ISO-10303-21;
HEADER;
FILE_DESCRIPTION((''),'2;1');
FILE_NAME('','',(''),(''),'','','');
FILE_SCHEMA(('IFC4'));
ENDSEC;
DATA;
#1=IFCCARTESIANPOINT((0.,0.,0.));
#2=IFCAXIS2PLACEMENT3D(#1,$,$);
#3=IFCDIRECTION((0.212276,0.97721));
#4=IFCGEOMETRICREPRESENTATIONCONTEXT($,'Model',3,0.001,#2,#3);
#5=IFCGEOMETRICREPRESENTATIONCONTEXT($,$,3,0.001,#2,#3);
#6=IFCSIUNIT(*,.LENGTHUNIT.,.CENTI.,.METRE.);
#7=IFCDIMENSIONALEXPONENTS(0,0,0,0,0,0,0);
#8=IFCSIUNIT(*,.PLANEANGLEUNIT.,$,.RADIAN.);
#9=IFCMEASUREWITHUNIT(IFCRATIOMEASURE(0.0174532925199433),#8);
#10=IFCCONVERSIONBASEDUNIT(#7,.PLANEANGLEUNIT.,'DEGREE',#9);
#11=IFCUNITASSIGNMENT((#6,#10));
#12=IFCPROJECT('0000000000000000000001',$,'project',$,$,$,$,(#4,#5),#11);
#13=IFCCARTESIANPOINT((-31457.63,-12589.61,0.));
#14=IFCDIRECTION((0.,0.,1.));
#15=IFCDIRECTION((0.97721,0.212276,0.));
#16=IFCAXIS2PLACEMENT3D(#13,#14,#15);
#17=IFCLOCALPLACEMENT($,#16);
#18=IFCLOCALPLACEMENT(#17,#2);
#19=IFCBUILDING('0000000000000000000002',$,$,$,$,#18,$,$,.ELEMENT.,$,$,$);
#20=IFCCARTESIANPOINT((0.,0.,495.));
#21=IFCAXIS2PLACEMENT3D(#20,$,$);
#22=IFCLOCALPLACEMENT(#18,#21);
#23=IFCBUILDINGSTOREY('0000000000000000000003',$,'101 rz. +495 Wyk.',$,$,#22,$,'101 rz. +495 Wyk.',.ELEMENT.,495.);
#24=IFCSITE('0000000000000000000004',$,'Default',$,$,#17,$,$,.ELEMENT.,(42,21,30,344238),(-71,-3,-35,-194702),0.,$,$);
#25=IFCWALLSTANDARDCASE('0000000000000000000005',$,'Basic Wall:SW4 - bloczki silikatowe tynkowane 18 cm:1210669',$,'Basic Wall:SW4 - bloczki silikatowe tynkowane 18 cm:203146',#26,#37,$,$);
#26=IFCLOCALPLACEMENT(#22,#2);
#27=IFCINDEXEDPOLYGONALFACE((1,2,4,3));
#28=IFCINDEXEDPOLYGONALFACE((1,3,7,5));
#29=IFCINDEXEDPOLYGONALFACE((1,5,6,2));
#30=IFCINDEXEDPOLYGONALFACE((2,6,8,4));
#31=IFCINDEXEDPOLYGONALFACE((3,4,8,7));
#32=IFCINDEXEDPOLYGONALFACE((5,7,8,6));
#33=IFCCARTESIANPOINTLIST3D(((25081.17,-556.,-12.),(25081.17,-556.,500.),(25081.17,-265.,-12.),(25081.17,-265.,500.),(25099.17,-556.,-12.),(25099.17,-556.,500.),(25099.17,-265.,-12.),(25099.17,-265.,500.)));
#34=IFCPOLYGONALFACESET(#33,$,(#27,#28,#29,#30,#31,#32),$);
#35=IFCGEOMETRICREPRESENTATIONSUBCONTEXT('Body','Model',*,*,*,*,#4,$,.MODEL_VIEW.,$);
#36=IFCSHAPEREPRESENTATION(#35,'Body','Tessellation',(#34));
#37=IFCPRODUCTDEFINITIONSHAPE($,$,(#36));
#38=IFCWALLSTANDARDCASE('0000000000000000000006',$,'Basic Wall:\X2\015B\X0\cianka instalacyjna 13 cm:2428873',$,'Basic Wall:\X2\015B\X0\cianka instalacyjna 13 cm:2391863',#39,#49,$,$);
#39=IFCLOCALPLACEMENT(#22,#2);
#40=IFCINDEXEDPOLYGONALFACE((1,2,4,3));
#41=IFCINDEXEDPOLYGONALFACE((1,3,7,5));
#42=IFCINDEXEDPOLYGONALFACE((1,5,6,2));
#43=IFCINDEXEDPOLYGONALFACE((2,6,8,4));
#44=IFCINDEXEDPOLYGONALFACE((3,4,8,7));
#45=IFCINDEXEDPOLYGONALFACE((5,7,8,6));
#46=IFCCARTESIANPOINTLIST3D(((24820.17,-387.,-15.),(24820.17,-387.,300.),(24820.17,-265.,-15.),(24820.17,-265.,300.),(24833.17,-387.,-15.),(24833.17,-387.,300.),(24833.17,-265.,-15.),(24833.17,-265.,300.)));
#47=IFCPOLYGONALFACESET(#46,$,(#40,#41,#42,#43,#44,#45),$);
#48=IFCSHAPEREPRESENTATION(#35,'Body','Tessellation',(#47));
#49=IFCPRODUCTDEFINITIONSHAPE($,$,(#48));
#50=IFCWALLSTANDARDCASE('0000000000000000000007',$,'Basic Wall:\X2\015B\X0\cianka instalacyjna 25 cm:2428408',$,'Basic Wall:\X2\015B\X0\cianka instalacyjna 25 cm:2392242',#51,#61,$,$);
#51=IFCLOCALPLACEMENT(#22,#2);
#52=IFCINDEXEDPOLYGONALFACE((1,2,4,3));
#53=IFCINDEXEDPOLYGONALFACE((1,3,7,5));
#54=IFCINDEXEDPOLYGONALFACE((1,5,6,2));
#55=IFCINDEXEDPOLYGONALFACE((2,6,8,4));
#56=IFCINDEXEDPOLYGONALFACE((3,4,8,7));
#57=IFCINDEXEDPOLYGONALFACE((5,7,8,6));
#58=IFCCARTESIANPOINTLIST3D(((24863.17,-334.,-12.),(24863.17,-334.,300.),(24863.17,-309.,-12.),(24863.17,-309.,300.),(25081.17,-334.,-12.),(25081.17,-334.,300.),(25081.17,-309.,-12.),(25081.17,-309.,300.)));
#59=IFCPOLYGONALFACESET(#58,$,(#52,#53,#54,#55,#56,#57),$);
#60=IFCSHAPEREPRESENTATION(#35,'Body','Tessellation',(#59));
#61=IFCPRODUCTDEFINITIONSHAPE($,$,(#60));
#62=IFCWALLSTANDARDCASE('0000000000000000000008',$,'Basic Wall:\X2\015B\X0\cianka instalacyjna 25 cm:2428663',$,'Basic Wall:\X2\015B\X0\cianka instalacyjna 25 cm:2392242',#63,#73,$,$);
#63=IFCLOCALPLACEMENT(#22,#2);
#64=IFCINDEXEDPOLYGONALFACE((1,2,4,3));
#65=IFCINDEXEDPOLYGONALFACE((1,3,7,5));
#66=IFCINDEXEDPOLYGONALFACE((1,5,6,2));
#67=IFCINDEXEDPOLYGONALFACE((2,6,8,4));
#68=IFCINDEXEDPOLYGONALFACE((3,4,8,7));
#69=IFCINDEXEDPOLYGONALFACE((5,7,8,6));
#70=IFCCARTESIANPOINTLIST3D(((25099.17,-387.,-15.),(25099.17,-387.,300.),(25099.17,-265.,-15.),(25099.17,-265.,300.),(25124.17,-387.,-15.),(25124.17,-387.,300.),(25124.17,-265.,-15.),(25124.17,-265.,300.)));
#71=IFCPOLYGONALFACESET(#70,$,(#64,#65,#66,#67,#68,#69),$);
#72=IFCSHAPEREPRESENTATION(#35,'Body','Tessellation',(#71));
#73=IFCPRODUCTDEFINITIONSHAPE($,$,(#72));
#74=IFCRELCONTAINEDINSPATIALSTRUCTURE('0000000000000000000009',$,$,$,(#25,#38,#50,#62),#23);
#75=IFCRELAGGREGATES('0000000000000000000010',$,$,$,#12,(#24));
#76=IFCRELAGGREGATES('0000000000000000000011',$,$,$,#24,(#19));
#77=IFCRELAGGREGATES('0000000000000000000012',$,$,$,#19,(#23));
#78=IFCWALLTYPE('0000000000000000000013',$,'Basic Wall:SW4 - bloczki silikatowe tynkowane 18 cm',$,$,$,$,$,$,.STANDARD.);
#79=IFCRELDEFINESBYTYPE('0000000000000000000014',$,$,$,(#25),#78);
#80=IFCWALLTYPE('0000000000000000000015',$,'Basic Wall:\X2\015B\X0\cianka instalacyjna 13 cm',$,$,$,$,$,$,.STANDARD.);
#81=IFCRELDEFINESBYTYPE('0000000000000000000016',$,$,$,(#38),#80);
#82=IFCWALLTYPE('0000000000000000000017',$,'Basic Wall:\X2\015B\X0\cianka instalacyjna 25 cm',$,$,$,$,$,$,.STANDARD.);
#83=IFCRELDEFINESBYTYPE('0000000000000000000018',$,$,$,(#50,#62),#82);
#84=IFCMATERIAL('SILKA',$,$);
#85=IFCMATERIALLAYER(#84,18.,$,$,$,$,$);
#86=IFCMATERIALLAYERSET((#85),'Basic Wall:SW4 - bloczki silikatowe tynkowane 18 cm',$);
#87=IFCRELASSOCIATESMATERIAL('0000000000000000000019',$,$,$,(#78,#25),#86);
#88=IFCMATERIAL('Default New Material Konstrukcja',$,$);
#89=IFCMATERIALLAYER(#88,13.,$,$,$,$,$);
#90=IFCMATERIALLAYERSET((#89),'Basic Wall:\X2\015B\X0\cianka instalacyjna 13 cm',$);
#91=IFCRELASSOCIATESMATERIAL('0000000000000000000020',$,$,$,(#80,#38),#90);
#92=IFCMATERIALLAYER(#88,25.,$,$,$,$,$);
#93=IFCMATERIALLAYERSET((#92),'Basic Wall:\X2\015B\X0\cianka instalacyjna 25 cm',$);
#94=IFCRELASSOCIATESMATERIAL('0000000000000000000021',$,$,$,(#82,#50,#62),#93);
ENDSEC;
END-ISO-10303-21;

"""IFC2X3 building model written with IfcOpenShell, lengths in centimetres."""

from ifc_helpers import new_model, entity, si_unit, converted_unit, direction, frame, frame_2d, origin, place, context, subcontext, project, spatial, polyline, rectangle, extrude, clip, bounded_halfspace, material, layer, layer_set, layer_usage, type_object, element, save


model = new_model("IFC2X3")

# Units and contexts
model_context = context("Model", 3, precision=0.001, world=origin(), true_north=direction((0.212276, 0.97721)))
context_of_model = context(None, 3, precision=0.001, world=origin(), true_north=direction((0.212276, 0.97721)))
body_context = subcontext(model_context, "Body", "Model", "MODEL_VIEW")
ifc_project = project(units=[si_unit("LENGTHUNIT", "METRE", prefix="CENTI"), converted_unit("PLANEANGLEUNIT", "DEGREE", entity("IfcRatioMeasure", 0.0174532925199433), si_unit("PLANEANGLEUNIT", "RADIAN"), dimensions=[0, 0, 0, 0, 0, 0, 0])], contexts=[model_context, context_of_model])

# Site, building, storey
site_placement = place(None, frame((-31457.63, -12589.61, 0.0), z_axis=(0.0, 0.0, 1.0), x_axis=(0.97721, 0.212276, 0.0)))
site = spatial("IfcSite", under=ifc_project, at=site_placement, Name="Default", CompositionType="ELEMENT", RefLatitude=(42, 21, 30, 344238), RefLongitude=(-71, -3, -35, -194702), RefElevation=0.0)
building_placement = place(site_placement, origin())
building = spatial("IfcBuilding", under=site, at=building_placement, CompositionType="ELEMENT")
storey_placement = place(building_placement, frame((0.0, 0.0, 495.0)))
storey = spatial("IfcBuildingStorey", under=building, at=storey_placement, Name="101 rz. +495 Wyk.", LongName="101 rz. +495 Wyk.", CompositionType="ELEMENT", Elevation=495.0)

# Shared definitions
ifc_material_1 = material(Name="SILKA")
ifc_layer_1 = layer(ifc_material_1, 18.0)
ifc_layer_set_1 = layer_set([ifc_layer_1], Name="Basic Wall:SW4 - bloczki silikatowe tynkowane 18 cm")
wall_type_1 = type_object("IfcWallType", Name="Basic Wall:SW4 - bloczki silikatowe tynkowane 18 cm", PredefinedType="STANDARD", material=ifc_layer_set_1)

# Wall
ifc_layer_usage_1 = layer_usage(ifc_layer_set_1, "AXIS2", "NEGATIVE", 9.0)
wall_1_placement = place(storey_placement, frame((25090.17, -265.0, -12.0), z_axis=(0.0, 0.0, 1.0), x_axis=(0.0, -1.0, 0.0)))
element("IfcWallStandardCase", 1, at=wall_1_placement, inside=storey, type_object=wall_type_1, material=ifc_layer_usage_1, Name="Basic Wall:SW4 - bloczki silikatowe tynkowane 18 cm:1210669", ObjectType="Basic Wall:SW4 - bloczki silikatowe tynkowane 18 cm:203146", context=body_context, shape_type="Clipping", body=[
    clip(extrude(rectangle(XDim=291.0, YDim=18.0, at=frame_2d((145.5, 0.0), x_axis=(-1.0, 0.0))), origin(), (0.0, 0.0, 1.0), 537.0), bounded_halfspace(frame((0.0, -9.0, 512.0), z_axis=(0.0, 0.0, -1.0), x_axis=(0.0, 1.0, 0.0)), True, frame((0.0, -9.0, 512.0)), polyline([(0.0, 0.0), (26.0, 0.0), (44.0, 0.0), (291.0, 0.0), (291.0, 18.0), (130.0, 18.0), (122.0, 18.0), (0.0, 18.0), (0.0, 0.0)]))),
])

# Walls
ifc_material_2 = material(Name="Default New Material Konstrukcja")
ifc_layer_2 = layer(ifc_material_2, 13.0)
ifc_layer_set_2 = layer_set([ifc_layer_2], Name="Basic Wall:ścianka instalacyjna 13 cm")
ifc_layer_usage_2 = layer_usage(ifc_layer_set_2, "AXIS2", "NEGATIVE", 6.5)
wall_type_2 = type_object("IfcWallType", Name="Basic Wall:ścianka instalacyjna 13 cm", PredefinedType="STANDARD", material=ifc_layer_set_2)
wall_2_placement = place(storey_placement, frame((24826.67, -387.0, -15.0), z_axis=(0.0, 0.0, 1.0), x_axis=(0.0, 1.0, 0.0)))
element("IfcWallStandardCase", 2, at=wall_2_placement, inside=storey, type_object=wall_type_2, material=ifc_layer_usage_2, Name="Basic Wall:ścianka instalacyjna 13 cm:2428873", ObjectType="Basic Wall:ścianka instalacyjna 13 cm:2391863", context=body_context, shape_type="SweptSolid", body=[
    extrude(rectangle(XDim=122.0, YDim=13.0, at=frame_2d((61.0, 0.0), x_axis=(-1.0, 0.0))), origin(), (0.0, 0.0, 1.0), 315.0),
])
ifc_layer_3 = layer(ifc_material_2, 25.0)
ifc_layer_set_3 = layer_set([ifc_layer_3], Name="Basic Wall:ścianka instalacyjna 25 cm")
ifc_layer_usage_3 = layer_usage(ifc_layer_set_3, "AXIS2", "NEGATIVE", 12.5)
wall_type_3 = type_object("IfcWallType", Name="Basic Wall:ścianka instalacyjna 25 cm", PredefinedType="STANDARD", material=ifc_layer_set_3)
wall_3_placement = place(storey_placement, frame((25081.17, -321.5, -12.0), z_axis=(0.0, 0.0, 1.0), x_axis=(-1.0, 0.0, 0.0)))
element("IfcWallStandardCase", 3, at=wall_3_placement, inside=storey, type_object=wall_type_3, material=ifc_layer_usage_3, Name="Basic Wall:ścianka instalacyjna 25 cm:2428408", ObjectType="Basic Wall:ścianka instalacyjna 25 cm:2392242", context=body_context, shape_type="SweptSolid", body=[
    extrude(rectangle(XDim=218.0, YDim=25.0, at=frame_2d((109.0, 0.0), x_axis=(-1.0, 0.0))), origin(), (0.0, 0.0, 1.0), 312.0),
])
ifc_layer_usage_4 = layer_usage(ifc_layer_set_3, "AXIS2", "NEGATIVE", 12.5)
wall_4_placement = place(storey_placement, frame((25111.67, -265.0, -15.0), z_axis=(0.0, 0.0, 1.0), x_axis=(0.0, -1.0, 0.0)))
element("IfcWallStandardCase", 4, at=wall_4_placement, inside=storey, type_object=wall_type_3, material=ifc_layer_usage_4, Name="Basic Wall:ścianka instalacyjna 25 cm:2428663", ObjectType="Basic Wall:ścianka instalacyjna 25 cm:2392242", context=body_context, shape_type="SweptSolid", body=[
    extrude(rectangle(XDim=122.0, YDim=25.0, at=frame_2d((61.0, 0.0), x_axis=(-1.0, 0.0))), origin(), (0.0, 0.0, 1.0), 315.0),
])

save(model, "model.ifc")
